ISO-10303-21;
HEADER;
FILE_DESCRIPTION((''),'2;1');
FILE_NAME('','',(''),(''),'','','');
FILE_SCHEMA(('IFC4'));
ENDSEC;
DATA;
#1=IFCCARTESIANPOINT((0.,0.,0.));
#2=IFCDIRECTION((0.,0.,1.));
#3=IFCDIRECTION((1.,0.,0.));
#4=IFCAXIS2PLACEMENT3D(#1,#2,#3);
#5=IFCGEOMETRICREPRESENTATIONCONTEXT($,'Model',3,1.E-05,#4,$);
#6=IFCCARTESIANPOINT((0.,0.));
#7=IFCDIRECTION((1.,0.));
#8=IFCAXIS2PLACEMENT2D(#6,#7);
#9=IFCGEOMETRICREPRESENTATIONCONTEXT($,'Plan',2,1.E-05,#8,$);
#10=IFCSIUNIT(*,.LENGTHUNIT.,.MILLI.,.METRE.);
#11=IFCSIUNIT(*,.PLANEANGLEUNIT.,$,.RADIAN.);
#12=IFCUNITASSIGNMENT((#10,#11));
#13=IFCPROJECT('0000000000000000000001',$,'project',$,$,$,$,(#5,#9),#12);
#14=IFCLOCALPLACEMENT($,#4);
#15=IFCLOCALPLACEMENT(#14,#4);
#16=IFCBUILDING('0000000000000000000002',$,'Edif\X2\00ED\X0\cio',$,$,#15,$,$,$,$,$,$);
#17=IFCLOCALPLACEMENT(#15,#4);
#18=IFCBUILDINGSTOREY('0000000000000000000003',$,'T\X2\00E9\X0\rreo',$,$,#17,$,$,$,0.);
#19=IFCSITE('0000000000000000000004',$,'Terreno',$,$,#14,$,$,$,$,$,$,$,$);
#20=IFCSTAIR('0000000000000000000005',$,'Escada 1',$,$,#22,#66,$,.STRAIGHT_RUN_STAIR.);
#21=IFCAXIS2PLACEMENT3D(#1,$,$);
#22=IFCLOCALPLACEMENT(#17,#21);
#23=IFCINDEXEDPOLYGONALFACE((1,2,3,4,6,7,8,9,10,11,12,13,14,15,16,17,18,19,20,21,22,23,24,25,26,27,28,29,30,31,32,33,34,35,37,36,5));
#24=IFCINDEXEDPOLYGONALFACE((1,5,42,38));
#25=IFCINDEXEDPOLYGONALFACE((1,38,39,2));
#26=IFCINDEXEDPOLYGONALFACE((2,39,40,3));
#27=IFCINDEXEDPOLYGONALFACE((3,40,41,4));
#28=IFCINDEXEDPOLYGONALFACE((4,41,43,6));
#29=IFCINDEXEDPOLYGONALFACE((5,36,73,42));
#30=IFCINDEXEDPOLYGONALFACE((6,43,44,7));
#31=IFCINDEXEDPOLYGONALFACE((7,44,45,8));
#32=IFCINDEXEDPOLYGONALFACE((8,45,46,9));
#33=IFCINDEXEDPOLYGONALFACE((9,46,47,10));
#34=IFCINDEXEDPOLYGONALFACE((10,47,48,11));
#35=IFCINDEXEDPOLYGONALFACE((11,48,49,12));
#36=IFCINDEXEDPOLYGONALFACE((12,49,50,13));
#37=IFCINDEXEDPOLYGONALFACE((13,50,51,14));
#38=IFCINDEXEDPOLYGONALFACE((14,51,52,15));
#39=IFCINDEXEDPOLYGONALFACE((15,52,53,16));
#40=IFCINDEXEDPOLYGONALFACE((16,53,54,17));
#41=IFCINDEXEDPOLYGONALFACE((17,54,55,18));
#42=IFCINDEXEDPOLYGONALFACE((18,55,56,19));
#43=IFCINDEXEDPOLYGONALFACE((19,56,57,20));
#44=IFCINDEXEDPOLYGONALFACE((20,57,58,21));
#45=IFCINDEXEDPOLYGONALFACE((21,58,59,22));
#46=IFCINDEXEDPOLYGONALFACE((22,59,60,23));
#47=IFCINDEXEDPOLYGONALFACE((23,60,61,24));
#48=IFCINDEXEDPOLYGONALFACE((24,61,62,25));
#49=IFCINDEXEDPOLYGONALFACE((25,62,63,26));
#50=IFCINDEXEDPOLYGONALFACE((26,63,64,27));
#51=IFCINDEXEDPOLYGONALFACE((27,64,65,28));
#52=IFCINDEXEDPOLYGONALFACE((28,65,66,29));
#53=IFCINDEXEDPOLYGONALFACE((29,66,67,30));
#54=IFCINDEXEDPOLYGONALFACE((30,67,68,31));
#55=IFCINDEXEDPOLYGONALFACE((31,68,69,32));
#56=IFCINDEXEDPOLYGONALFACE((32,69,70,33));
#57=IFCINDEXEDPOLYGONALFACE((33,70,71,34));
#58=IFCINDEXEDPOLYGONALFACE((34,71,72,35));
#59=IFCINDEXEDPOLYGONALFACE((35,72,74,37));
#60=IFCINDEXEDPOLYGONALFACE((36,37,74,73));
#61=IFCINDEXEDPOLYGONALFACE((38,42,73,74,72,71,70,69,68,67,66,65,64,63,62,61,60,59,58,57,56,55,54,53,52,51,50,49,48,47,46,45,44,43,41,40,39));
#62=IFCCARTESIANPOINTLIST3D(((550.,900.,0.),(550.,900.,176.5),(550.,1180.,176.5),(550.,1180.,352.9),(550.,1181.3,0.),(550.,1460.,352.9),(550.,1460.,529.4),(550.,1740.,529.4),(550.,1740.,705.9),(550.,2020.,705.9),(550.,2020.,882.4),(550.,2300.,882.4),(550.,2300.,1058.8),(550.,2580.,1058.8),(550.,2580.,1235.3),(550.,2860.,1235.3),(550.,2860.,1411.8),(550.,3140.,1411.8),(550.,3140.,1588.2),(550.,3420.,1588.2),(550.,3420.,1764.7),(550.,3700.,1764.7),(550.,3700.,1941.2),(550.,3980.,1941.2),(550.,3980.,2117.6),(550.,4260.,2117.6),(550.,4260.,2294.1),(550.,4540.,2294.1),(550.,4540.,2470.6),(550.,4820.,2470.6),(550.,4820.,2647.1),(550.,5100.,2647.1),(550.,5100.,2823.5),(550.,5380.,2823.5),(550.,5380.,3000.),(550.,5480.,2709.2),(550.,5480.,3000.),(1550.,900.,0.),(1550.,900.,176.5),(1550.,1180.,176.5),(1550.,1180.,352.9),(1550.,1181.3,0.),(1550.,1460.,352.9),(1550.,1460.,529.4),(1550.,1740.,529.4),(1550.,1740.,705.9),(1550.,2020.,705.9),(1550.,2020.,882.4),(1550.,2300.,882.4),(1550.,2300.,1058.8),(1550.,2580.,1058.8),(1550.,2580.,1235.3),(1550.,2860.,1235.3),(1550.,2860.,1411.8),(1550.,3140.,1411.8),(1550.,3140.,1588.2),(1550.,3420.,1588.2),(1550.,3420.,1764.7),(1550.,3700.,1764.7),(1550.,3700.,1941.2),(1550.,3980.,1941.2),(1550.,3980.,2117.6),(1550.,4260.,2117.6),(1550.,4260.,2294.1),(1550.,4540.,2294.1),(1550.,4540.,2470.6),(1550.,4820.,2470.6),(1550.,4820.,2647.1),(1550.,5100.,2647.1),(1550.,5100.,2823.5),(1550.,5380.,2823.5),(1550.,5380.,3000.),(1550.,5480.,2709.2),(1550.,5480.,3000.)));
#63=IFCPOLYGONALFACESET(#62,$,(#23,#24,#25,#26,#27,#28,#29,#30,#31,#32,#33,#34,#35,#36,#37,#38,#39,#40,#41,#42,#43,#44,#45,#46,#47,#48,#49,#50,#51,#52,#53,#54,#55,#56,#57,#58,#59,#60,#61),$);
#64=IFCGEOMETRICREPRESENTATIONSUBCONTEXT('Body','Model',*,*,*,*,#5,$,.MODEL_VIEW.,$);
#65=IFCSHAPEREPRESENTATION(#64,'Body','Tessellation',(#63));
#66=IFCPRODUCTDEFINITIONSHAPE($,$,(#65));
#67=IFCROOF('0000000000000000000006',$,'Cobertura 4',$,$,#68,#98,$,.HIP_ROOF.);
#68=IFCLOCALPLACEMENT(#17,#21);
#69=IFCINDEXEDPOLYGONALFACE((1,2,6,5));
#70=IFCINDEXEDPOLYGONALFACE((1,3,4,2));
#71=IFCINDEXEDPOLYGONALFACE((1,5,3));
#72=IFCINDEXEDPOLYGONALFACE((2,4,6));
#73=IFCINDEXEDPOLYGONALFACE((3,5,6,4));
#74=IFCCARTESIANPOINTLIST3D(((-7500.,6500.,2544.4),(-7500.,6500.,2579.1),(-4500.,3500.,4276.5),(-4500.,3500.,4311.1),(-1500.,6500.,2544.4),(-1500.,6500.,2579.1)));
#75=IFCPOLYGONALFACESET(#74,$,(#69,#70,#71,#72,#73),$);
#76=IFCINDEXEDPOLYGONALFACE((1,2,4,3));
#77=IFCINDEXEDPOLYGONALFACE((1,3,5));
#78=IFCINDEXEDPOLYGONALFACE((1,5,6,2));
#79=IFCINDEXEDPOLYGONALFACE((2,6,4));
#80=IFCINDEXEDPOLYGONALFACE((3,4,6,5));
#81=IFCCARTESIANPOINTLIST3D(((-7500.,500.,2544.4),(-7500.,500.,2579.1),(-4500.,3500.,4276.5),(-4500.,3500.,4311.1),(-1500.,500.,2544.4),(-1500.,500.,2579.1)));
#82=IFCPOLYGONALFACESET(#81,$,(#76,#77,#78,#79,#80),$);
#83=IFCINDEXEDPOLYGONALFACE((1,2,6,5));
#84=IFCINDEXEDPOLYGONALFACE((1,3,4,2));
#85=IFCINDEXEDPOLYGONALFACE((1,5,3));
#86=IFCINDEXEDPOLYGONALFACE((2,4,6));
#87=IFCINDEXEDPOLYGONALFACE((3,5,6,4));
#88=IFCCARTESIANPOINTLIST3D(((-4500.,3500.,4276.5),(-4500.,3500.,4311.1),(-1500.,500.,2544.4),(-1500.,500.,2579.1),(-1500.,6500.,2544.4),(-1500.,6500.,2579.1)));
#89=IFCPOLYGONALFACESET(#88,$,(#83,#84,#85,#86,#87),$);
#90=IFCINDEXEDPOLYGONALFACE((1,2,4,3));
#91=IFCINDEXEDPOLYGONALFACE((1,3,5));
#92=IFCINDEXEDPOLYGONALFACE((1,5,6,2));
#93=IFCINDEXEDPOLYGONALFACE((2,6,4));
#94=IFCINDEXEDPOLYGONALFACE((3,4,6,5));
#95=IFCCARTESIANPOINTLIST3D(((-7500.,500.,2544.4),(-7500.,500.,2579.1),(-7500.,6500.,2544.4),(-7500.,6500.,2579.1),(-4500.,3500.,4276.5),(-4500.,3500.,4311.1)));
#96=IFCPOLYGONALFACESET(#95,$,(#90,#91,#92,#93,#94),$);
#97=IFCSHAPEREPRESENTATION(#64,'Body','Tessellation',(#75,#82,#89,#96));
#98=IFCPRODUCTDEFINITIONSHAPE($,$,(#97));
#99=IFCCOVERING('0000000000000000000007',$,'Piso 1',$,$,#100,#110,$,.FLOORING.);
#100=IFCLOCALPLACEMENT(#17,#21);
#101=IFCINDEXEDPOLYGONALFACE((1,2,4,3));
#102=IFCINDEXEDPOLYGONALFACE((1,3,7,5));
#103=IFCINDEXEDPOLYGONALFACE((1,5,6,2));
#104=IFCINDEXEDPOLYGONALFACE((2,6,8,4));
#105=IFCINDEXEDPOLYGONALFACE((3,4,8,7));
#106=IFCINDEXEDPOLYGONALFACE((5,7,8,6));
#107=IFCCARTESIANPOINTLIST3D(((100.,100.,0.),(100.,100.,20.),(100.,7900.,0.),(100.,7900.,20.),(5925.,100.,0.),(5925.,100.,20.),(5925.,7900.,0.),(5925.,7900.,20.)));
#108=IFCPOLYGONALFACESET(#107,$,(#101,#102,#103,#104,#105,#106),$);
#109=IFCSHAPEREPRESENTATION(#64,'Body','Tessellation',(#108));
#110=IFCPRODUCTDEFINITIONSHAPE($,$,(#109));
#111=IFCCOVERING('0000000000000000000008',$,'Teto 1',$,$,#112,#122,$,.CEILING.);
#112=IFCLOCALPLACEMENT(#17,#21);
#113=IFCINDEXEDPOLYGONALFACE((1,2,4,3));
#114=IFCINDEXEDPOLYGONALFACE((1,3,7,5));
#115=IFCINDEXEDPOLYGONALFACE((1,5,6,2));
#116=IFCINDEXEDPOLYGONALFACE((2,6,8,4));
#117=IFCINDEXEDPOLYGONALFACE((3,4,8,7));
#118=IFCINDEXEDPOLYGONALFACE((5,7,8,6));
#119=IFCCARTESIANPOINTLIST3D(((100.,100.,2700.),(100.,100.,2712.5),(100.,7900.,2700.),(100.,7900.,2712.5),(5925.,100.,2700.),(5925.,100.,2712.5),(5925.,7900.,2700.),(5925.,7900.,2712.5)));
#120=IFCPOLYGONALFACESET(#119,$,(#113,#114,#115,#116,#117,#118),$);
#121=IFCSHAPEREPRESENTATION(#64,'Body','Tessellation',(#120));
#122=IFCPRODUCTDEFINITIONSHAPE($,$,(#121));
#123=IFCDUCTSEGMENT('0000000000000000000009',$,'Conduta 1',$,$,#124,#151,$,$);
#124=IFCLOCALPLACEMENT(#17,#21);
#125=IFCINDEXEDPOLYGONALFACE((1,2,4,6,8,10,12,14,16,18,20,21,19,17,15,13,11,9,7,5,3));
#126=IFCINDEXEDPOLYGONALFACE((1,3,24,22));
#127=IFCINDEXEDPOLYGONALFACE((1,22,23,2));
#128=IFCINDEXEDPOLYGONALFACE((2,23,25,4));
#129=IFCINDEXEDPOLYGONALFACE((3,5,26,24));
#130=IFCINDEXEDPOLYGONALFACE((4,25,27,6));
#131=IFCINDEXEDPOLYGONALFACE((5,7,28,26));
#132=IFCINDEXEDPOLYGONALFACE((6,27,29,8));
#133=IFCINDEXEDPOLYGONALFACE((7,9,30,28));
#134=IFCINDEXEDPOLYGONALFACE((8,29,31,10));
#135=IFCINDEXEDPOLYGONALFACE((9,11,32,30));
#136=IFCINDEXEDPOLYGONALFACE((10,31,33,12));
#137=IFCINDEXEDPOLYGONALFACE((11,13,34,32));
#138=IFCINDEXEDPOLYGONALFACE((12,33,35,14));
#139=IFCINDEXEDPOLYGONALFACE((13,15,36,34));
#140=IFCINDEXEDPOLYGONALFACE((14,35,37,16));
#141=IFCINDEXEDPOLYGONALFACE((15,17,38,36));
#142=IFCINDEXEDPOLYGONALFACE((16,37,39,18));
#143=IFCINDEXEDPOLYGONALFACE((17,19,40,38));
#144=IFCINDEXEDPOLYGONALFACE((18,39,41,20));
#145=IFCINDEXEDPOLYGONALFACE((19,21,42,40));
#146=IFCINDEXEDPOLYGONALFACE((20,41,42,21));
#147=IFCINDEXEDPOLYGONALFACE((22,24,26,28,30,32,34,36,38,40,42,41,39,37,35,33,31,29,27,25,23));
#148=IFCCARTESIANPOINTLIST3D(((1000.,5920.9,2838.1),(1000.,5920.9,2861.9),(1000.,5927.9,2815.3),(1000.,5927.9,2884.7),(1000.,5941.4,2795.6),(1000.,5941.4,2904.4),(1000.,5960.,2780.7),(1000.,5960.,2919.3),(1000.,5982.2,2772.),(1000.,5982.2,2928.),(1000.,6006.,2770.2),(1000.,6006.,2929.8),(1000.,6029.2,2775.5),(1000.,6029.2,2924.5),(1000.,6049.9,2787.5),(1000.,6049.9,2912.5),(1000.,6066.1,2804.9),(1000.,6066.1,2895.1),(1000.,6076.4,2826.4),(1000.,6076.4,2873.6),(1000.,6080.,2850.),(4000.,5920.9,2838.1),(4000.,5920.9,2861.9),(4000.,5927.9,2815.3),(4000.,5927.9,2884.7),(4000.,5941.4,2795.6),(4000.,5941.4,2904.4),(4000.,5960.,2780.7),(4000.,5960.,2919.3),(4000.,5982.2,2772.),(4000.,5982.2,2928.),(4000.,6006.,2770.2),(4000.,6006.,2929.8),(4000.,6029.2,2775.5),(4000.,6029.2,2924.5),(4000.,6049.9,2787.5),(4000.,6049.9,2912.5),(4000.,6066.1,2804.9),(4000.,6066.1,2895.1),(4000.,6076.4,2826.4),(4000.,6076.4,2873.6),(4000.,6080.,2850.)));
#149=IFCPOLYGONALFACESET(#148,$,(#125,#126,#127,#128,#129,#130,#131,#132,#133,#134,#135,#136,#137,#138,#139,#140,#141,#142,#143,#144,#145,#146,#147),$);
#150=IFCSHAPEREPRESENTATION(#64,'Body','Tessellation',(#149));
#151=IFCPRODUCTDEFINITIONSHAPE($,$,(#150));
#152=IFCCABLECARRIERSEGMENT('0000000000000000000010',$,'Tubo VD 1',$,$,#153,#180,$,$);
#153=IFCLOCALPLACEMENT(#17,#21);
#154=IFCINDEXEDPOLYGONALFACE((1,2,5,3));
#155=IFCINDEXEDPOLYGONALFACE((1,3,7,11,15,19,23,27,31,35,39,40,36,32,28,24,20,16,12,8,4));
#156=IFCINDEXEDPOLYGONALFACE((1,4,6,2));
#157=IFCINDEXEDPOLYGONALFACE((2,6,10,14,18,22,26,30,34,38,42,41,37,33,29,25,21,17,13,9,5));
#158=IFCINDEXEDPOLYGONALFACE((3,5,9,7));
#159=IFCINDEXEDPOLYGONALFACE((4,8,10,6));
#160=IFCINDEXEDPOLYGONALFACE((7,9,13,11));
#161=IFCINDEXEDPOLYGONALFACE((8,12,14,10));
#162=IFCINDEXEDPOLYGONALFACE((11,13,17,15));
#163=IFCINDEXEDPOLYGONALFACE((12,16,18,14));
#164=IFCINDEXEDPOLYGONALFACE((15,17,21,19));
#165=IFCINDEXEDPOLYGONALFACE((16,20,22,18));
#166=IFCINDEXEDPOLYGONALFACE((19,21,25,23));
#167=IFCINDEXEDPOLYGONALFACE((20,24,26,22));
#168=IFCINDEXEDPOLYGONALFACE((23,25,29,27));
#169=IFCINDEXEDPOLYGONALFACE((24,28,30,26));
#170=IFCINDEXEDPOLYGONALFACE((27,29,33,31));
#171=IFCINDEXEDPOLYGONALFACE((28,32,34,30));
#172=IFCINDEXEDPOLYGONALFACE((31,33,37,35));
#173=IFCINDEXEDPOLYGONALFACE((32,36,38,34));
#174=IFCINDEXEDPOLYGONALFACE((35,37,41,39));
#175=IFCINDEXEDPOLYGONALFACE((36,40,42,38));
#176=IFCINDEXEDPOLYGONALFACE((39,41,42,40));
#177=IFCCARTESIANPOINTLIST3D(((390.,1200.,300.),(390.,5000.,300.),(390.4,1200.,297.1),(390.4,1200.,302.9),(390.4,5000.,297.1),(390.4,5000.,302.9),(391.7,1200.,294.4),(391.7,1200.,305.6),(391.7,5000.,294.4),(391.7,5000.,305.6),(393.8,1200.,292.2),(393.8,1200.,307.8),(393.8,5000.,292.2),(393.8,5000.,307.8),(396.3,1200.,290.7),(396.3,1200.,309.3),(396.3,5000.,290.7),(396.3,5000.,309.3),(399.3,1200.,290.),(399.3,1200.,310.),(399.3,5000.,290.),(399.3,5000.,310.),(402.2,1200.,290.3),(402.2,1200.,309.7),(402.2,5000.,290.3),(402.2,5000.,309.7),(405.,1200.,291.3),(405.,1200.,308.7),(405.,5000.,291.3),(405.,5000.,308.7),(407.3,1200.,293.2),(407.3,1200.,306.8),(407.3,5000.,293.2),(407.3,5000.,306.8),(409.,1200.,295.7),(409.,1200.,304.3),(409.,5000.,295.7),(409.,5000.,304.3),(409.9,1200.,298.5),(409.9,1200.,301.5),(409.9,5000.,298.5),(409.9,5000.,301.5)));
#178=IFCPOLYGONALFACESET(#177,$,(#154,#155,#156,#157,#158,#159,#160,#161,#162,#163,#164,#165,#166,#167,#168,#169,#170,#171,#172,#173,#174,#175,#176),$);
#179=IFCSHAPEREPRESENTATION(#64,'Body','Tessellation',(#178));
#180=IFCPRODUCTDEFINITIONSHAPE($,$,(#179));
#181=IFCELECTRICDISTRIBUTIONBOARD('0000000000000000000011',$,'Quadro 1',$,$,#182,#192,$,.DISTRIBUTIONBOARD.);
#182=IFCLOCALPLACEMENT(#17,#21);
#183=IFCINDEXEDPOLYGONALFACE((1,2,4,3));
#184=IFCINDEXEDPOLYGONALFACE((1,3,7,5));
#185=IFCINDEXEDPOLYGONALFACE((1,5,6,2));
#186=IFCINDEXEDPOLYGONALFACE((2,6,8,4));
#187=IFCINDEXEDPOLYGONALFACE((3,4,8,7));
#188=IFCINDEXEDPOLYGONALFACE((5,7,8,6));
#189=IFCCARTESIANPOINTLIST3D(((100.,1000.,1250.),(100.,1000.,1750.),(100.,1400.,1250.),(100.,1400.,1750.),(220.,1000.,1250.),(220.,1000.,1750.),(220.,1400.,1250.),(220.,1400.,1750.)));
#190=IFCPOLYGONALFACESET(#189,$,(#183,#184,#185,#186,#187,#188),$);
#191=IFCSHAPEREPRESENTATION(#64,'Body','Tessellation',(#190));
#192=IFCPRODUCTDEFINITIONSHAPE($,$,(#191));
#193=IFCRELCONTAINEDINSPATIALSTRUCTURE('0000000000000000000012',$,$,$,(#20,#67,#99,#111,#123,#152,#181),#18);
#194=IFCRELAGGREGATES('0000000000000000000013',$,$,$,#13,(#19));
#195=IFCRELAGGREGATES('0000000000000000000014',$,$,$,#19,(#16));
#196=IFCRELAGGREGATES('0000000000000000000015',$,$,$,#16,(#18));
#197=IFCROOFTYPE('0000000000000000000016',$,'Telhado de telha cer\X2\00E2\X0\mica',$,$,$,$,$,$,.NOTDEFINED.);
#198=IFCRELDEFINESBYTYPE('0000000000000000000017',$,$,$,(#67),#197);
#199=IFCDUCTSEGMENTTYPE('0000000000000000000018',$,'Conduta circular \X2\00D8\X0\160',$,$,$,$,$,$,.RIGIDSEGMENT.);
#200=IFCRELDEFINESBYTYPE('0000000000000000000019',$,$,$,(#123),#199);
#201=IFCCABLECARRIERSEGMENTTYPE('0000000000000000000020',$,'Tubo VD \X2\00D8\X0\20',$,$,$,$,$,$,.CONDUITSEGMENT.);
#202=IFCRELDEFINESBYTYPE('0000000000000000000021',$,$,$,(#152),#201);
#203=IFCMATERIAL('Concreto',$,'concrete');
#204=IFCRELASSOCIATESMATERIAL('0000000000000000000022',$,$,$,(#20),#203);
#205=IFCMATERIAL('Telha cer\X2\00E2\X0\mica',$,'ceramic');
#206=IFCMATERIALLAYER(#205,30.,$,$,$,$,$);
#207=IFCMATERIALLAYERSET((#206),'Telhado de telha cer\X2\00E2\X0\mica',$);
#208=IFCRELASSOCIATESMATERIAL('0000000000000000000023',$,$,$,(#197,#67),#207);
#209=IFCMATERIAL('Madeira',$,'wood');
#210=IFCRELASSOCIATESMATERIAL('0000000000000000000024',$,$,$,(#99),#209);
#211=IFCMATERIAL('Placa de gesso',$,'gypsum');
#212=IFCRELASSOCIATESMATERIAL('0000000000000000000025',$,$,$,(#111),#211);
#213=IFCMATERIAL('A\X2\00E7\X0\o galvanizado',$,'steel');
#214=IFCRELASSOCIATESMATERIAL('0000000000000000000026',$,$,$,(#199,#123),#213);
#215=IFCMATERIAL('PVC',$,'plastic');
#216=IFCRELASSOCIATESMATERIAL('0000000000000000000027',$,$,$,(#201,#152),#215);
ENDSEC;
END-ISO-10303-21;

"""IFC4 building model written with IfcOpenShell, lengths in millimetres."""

from ifc_helpers import new_model, si_unit, frame, frame_2d, origin, origin_with_axes, origin_2d_with_axis, place, context, subcontext, project, spatial, indexed_curve, rectangle, circle, outline, extrude, material, layer, layer_set, material_profile, profile_set, profile_usage, type_object, element, save


model = new_model("IFC4")

# Units and contexts
model_context = context("Model", 3, precision=1e-05, world=origin_with_axes())
plan_context = context("Plan", 2, precision=1e-05, world=origin_2d_with_axis())
body_context = subcontext(model_context, "Body", "Model", "MODEL_VIEW")
ifc_project = project(units=[si_unit("LENGTHUNIT", "METRE", prefix="MILLI"), si_unit("PLANEANGLEUNIT", "RADIAN")], contexts=[model_context, plan_context])

# Site, building, storey
site_placement = place(None, origin_with_axes())
site = spatial("IfcSite", under=ifc_project, at=site_placement, Name="Terreno")
building_placement = place(site_placement, origin_with_axes())
building = spatial("IfcBuilding", under=site, at=building_placement, Name="Edifício")
storey_placement = place(building_placement, origin_with_axes())
storey = spatial("IfcBuildingStorey", under=building, at=storey_placement, Name="Térreo", Elevation=0.0)

# Shared definitions
ifc_material_1 = material(Name="Concreto", Category="concrete")

# Shared definitions
ifc_material_2 = material(Name="Placa de gesso", Category="gypsum")

# Stair
stair_placement = place(storey_placement, frame((1050.0, 900.0, 0.0), z_axis=(0.0, 0.0, 1.0), x_axis=(0.0, 1.0, 0.0)))
element("IfcStair", 1, at=stair_placement, inside=storey, material=ifc_material_1, Name="Escada 1", PredefinedType="STRAIGHT_RUN_STAIR", context=body_context, shape_type="SweptSolid", body=[
    extrude(outline(indexed_curve([(281.3, 0.0), (4580.0, 2709.2), (4580.0, 3000.0), (4480.0, 3000.0), (4480.0, 2823.5), (4200.0, 2823.5), (4200.0, 2647.1), (3920.0, 2647.1), (3920.0, 2470.6), (3640.0, 2470.6), (3640.0, 2294.1), (3360.0, 2294.1), (3360.0, 2117.6), (3080.0, 2117.6), (3080.0, 1941.2), (2800.0, 1941.2), (2800.0, 1764.7), (2520.0, 1764.7), (2520.0, 1588.2), (2240.0, 1588.2), (2240.0, 1411.8), (1960.0, 1411.8), (1960.0, 1235.3), (1680.0, 1235.3), (1680.0, 1058.8), (1400.0, 1058.8), (1400.0, 882.4), (1120.0, 882.4), (1120.0, 705.9), (840.0, 705.9), (840.0, 529.4), (560.0, 529.4), (560.0, 352.9), (280.0, 352.9), (280.0, 176.5), (0.0, 176.5), (0.0, 0.0), (281.3, 0.0)], self_intersect=False)), frame((0.0, 500.0, 0.0), z_axis=(0.0, -1.0, 0.0), x_axis=(1.0, 0.0, 0.0)), (0.0, 0.0, 1.0), 1000.0),
])

# Roof
ifc_material_3 = material(Name="Telha cerâmica", Category="ceramic")
ifc_layer_1 = layer(ifc_material_3, 30.0)
ifc_layer_set_1 = layer_set([ifc_layer_1], Name="Telhado de telha cerâmica")
roof_type = type_object("IfcRoofType", Name="Telhado de telha cerâmica", PredefinedType="NOTDEFINED", material=ifc_layer_set_1)
roof_placement = place(storey_placement, frame((-4500.0, 3500.0, 2800.0), z_axis=(0.0, 0.0, 1.0), x_axis=(1.0, 0.0, 0.0)))
element("IfcRoof", 2, at=roof_placement, inside=storey, type_object=roof_type, material=ifc_layer_set_1, Name="Cobertura 4", PredefinedType="HIP_ROOF", context=body_context, shape_type="SweptSolid", body=[
    extrude(outline(indexed_curve([(0.0, 0.0), (-6000.0, 0.0), (-3000.0, -3464.1), (0.0, 0.0)], self_intersect=False)), frame((3000.0, 3000.0, -220.9), z_axis=(0.0, 0.5, 0.866025), x_axis=(1.0, 0.0, 0.0)), (0.0, 0.5, -0.866025), 34.6),
    extrude(outline(indexed_curve([(0.0, 0.0), (-6000.0, 0.0), (-3000.0, -3464.1), (0.0, 0.0)], self_intersect=False)), frame((-3000.0, -3000.0, -220.9), z_axis=(0.0, -0.5, 0.866025), x_axis=(-1.0, 0.0, 0.0)), (0.0, 0.5, -0.866025), 34.6),
    extrude(outline(indexed_curve([(0.0, 0.0), (-6000.0, 0.0), (-3000.0, -3464.1), (0.0, 0.0)], self_intersect=False)), frame((3000.0, -3000.0, -220.9), z_axis=(0.5, 0.0, 0.866025), x_axis=(0.0, -1.0, 0.0)), (0.0, 0.5, -0.866025), 34.6),
    extrude(outline(indexed_curve([(0.0, 0.0), (3000.0, -3464.1), (6000.0, 0.0), (0.0, 0.0)], self_intersect=False)), frame((-3000.0, -3000.0, -220.9), z_axis=(-0.5, 0.0, 0.866025), x_axis=(0.0, 1.0, 0.0)), (0.0, 0.5, -0.866025), 34.6),
])

# Coverings
ifc_material_4 = material(Name="Madeira", Category="wood")
covering_1_placement = place(storey_placement, frame((100.0, 100.0, 0.0), z_axis=(0.0, 0.0, 1.0), x_axis=(1.0, 0.0, 0.0)))
element("IfcCovering", 3, at=covering_1_placement, inside=storey, material=ifc_material_4, Name="Piso 1", PredefinedType="FLOORING", context=body_context, shape_type="SweptSolid", body=[
    extrude(outline(indexed_curve([(0.0, 0.0), (5825.0, 0.0), (5825.0, 7800.0), (0.0, 7800.0), (0.0, 0.0)], self_intersect=False)), origin(), (0.0, 0.0, 1.0), 20.0),
])
covering_2_placement = place(storey_placement, frame((100.0, 100.0, 2700.0), z_axis=(0.0, 0.0, 1.0), x_axis=(1.0, 0.0, 0.0)))
element("IfcCovering", 4, at=covering_2_placement, inside=storey, material=ifc_material_2, Name="Teto 1", PredefinedType="CEILING", context=body_context, shape_type="SweptSolid", body=[
    extrude(outline(indexed_curve([(0.0, 0.0), (5825.0, 0.0), (5825.0, 7800.0), (0.0, 7800.0), (0.0, 0.0)], self_intersect=False)), origin(), (0.0, 0.0, 1.0), 12.5),
])

# Duct segment
ifc_material_5 = material(Name="Aço galvanizado", Category="steel")
ifc_material_profile_1 = material_profile(ifc_material_5, circle(Radius=80.0))
ifc_profile_set_1 = profile_set([ifc_material_profile_1], Name="Conduta circular Ø160")
ifc_profile_usage_1 = profile_usage(ifc_profile_set_1)
duct_segment_type = type_object("IfcDuctSegmentType", Name="Conduta circular Ø160", PredefinedType="RIGIDSEGMENT", material=ifc_profile_set_1)
duct_segment_placement = place(storey_placement, frame((1000.0, 6000.0, 2850.0), z_axis=(1.0, 0.0, 0.0), x_axis=(0.0, 1.0, 0.0)))
element("IfcDuctSegment", 5, at=duct_segment_placement, inside=storey, type_object=duct_segment_type, material=ifc_profile_usage_1, Name="Conduta 1", context=body_context, shape_type="SweptSolid", body=[
    extrude(circle(Radius=80.0), origin_with_axes(), (0.0, 0.0, 1.0), 3000.0),
])

# Cable carrier segment
ifc_material_6 = material(Name="PVC", Category="plastic")
ifc_material_profile_2 = material_profile(ifc_material_6, circle(Radius=10.0))
ifc_profile_set_2 = profile_set([ifc_material_profile_2], Name="Tubo VD Ø20")
ifc_profile_usage_2 = profile_usage(ifc_profile_set_2)
cable_carrier_segment_type = type_object("IfcCableCarrierSegmentType", Name="Tubo VD Ø20", PredefinedType="CONDUITSEGMENT", material=ifc_profile_set_2)
cable_carrier_segment_placement = place(storey_placement, frame((400.0, 1200.0, 300.0), z_axis=(0.0, 1.0, 0.0), x_axis=(-1.0, 0.0, 0.0)))
element("IfcCableCarrierSegment", 6, at=cable_carrier_segment_placement, inside=storey, type_object=cable_carrier_segment_type, material=ifc_profile_usage_2, Name="Tubo VD 1", context=body_context, shape_type="SweptSolid", body=[
    extrude(circle(Radius=10.0), origin_with_axes(), (0.0, 0.0, 1.0), 3800.0),
])

# Electric distribution board
electric_distribution_board_placement = place(storey_placement, frame((100.0, 1200.0, 0.0), z_axis=(0.0, 0.0, 1.0), x_axis=(0.0, -1.0, 0.0)))
element("IfcElectricDistributionBoard", 7, at=electric_distribution_board_placement, inside=storey, Name="Quadro 1", PredefinedType="DISTRIBUTIONBOARD", context=body_context, shape_type="SweptSolid", body=[
    extrude(rectangle(XDim=400.0, YDim=120.0, at=frame_2d((0.0, 60.0))), frame((0.0, 0.0, 1250.0)), (0.0, 0.0, 1.0), 500.0),
])

save(model, "model.ifc")
